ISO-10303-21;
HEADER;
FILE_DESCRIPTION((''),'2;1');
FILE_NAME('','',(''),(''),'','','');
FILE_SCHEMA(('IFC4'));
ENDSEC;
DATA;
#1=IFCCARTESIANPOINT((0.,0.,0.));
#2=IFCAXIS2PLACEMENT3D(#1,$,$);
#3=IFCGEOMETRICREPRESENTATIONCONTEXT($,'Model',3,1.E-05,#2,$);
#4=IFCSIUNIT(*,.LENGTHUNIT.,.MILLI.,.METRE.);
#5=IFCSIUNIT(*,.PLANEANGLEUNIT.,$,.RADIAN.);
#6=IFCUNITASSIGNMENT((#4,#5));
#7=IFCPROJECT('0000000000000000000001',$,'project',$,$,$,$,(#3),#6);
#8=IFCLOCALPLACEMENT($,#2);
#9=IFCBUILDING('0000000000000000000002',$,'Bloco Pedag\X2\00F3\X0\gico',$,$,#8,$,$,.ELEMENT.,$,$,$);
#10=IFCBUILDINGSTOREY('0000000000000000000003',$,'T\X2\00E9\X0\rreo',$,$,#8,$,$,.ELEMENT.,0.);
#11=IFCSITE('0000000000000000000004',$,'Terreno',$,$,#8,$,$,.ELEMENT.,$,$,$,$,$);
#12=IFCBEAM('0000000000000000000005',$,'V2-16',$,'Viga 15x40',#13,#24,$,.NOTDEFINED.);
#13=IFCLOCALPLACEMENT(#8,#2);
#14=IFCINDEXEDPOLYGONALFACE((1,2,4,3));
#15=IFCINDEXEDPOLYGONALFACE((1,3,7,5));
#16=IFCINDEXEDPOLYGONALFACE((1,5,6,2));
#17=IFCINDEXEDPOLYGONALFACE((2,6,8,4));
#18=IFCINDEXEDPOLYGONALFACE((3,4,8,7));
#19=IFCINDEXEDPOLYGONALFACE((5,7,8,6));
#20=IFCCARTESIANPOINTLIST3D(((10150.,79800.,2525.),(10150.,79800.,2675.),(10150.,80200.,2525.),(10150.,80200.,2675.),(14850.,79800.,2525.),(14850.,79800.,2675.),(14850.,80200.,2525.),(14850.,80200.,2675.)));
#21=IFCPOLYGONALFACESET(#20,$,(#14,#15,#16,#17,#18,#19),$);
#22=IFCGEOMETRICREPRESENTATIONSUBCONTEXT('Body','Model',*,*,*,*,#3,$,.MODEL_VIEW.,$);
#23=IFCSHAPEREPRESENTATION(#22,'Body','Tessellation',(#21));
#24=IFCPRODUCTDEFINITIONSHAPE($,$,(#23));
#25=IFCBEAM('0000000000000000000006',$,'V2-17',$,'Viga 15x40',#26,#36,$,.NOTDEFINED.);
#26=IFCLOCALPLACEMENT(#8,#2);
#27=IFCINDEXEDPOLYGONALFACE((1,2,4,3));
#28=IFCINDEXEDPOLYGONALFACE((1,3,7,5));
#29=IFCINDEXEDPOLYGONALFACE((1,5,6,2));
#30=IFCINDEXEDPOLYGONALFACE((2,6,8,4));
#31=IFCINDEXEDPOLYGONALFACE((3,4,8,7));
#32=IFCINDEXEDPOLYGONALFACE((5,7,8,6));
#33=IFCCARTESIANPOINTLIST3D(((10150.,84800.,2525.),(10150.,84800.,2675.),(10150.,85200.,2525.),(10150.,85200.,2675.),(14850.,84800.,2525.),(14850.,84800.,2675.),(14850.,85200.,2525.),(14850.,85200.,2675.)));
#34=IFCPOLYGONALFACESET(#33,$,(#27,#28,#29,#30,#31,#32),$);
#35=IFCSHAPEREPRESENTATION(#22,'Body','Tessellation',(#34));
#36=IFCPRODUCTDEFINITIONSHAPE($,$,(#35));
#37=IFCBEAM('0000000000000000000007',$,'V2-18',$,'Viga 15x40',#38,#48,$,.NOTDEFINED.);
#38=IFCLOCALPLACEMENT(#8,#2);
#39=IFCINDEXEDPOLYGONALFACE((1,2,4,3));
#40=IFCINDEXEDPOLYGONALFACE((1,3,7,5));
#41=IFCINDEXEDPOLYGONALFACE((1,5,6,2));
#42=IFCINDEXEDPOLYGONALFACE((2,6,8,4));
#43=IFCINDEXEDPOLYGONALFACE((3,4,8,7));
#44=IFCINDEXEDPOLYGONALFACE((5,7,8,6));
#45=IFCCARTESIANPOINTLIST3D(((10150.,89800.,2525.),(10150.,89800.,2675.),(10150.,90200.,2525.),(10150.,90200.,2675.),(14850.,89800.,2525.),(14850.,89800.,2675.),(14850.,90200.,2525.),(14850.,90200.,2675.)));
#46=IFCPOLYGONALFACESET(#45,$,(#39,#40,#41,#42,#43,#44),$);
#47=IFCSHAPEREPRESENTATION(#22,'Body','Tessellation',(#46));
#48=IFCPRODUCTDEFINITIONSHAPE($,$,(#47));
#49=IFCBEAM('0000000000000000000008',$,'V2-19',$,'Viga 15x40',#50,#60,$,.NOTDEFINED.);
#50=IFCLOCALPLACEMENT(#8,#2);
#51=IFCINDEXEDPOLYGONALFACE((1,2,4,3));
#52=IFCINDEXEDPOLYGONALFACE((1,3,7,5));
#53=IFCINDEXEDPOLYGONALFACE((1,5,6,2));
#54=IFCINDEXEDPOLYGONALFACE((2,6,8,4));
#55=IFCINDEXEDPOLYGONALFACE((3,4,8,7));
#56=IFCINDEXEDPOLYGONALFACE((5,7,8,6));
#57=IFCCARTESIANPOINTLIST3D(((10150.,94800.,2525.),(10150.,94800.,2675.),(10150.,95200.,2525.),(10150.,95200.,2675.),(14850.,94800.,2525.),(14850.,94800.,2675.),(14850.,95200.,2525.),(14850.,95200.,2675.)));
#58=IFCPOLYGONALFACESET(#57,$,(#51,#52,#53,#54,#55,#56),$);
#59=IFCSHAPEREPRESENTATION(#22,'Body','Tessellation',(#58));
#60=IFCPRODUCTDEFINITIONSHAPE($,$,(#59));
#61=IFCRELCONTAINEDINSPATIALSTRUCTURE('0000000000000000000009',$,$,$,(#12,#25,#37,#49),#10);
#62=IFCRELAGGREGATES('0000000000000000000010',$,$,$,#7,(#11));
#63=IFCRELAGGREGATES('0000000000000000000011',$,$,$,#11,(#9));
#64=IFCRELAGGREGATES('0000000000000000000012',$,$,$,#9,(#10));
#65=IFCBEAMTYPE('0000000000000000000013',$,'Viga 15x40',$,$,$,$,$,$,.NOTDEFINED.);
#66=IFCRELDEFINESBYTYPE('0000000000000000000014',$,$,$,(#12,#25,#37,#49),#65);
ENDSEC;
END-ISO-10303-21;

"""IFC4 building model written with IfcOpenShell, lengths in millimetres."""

from ifc_helpers import new_model, si_unit, frame, origin, origin_2d, place, context, subcontext, project, spatial, rectangle, extrude, type_object, element, save


model = new_model("IFC4")

# Units and contexts
model_context = context("Model", 3, precision=1e-05, world=origin())
body_context = subcontext(model_context, "Body", "Model", "MODEL_VIEW")
ifc_project = project(units=[si_unit("LENGTHUNIT", "METRE", prefix="MILLI"), si_unit("PLANEANGLEUNIT", "RADIAN")], contexts=[model_context])

# Site, building, storey
placement = place(None, origin())
site = spatial("IfcSite", under=ifc_project, at=placement, Name="Terreno", CompositionType="ELEMENT")
building = spatial("IfcBuilding", under=site, at=placement, Name="Bloco Pedagógico", CompositionType="ELEMENT")
storey = spatial("IfcBuildingStorey", under=building, at=placement, Name="Térreo", CompositionType="ELEMENT", Elevation=0.0)

# Beams
beam_type = type_object("IfcBeamType", Name="Viga 15x40", PredefinedType="NOTDEFINED")
for number, where, z_axis, x_axis, name in (
    (1, (10150.0, 80000.0, 2600.0), (1.0, 0.0, 0.0), (0.0, 1.0, 0.0), "V2-16"),
    (2, (10150.0, 85000.0, 2600.0), (1.0, 0.0, 0.0), (0.0, 1.0, 0.0), "V2-17"),
    (3, (10150.0, 90000.0, 2600.0), (1.0, 0.0, 0.0), (0.0, 1.0, 0.0), "V2-18"),
    (4, (10150.0, 95000.0, 2600.0), (1.0, 0.0, 0.0), (0.0, 1.0, 0.0), "V2-19"),
):
    element("IfcBeam", number, at=place(None, frame(where, z_axis=z_axis, x_axis=x_axis)), inside=storey, type_object=beam_type, Name=name, ObjectType="Viga 15x40", PredefinedType="NOTDEFINED", context=body_context, shape_type="SweptSolid", body=[
        extrude(rectangle(XDim=400.0, YDim=150.0, at=origin_2d()), None, (0.0, 0.0, 1.0), 4700.0),
    ])

save(model, "model.ifc")
